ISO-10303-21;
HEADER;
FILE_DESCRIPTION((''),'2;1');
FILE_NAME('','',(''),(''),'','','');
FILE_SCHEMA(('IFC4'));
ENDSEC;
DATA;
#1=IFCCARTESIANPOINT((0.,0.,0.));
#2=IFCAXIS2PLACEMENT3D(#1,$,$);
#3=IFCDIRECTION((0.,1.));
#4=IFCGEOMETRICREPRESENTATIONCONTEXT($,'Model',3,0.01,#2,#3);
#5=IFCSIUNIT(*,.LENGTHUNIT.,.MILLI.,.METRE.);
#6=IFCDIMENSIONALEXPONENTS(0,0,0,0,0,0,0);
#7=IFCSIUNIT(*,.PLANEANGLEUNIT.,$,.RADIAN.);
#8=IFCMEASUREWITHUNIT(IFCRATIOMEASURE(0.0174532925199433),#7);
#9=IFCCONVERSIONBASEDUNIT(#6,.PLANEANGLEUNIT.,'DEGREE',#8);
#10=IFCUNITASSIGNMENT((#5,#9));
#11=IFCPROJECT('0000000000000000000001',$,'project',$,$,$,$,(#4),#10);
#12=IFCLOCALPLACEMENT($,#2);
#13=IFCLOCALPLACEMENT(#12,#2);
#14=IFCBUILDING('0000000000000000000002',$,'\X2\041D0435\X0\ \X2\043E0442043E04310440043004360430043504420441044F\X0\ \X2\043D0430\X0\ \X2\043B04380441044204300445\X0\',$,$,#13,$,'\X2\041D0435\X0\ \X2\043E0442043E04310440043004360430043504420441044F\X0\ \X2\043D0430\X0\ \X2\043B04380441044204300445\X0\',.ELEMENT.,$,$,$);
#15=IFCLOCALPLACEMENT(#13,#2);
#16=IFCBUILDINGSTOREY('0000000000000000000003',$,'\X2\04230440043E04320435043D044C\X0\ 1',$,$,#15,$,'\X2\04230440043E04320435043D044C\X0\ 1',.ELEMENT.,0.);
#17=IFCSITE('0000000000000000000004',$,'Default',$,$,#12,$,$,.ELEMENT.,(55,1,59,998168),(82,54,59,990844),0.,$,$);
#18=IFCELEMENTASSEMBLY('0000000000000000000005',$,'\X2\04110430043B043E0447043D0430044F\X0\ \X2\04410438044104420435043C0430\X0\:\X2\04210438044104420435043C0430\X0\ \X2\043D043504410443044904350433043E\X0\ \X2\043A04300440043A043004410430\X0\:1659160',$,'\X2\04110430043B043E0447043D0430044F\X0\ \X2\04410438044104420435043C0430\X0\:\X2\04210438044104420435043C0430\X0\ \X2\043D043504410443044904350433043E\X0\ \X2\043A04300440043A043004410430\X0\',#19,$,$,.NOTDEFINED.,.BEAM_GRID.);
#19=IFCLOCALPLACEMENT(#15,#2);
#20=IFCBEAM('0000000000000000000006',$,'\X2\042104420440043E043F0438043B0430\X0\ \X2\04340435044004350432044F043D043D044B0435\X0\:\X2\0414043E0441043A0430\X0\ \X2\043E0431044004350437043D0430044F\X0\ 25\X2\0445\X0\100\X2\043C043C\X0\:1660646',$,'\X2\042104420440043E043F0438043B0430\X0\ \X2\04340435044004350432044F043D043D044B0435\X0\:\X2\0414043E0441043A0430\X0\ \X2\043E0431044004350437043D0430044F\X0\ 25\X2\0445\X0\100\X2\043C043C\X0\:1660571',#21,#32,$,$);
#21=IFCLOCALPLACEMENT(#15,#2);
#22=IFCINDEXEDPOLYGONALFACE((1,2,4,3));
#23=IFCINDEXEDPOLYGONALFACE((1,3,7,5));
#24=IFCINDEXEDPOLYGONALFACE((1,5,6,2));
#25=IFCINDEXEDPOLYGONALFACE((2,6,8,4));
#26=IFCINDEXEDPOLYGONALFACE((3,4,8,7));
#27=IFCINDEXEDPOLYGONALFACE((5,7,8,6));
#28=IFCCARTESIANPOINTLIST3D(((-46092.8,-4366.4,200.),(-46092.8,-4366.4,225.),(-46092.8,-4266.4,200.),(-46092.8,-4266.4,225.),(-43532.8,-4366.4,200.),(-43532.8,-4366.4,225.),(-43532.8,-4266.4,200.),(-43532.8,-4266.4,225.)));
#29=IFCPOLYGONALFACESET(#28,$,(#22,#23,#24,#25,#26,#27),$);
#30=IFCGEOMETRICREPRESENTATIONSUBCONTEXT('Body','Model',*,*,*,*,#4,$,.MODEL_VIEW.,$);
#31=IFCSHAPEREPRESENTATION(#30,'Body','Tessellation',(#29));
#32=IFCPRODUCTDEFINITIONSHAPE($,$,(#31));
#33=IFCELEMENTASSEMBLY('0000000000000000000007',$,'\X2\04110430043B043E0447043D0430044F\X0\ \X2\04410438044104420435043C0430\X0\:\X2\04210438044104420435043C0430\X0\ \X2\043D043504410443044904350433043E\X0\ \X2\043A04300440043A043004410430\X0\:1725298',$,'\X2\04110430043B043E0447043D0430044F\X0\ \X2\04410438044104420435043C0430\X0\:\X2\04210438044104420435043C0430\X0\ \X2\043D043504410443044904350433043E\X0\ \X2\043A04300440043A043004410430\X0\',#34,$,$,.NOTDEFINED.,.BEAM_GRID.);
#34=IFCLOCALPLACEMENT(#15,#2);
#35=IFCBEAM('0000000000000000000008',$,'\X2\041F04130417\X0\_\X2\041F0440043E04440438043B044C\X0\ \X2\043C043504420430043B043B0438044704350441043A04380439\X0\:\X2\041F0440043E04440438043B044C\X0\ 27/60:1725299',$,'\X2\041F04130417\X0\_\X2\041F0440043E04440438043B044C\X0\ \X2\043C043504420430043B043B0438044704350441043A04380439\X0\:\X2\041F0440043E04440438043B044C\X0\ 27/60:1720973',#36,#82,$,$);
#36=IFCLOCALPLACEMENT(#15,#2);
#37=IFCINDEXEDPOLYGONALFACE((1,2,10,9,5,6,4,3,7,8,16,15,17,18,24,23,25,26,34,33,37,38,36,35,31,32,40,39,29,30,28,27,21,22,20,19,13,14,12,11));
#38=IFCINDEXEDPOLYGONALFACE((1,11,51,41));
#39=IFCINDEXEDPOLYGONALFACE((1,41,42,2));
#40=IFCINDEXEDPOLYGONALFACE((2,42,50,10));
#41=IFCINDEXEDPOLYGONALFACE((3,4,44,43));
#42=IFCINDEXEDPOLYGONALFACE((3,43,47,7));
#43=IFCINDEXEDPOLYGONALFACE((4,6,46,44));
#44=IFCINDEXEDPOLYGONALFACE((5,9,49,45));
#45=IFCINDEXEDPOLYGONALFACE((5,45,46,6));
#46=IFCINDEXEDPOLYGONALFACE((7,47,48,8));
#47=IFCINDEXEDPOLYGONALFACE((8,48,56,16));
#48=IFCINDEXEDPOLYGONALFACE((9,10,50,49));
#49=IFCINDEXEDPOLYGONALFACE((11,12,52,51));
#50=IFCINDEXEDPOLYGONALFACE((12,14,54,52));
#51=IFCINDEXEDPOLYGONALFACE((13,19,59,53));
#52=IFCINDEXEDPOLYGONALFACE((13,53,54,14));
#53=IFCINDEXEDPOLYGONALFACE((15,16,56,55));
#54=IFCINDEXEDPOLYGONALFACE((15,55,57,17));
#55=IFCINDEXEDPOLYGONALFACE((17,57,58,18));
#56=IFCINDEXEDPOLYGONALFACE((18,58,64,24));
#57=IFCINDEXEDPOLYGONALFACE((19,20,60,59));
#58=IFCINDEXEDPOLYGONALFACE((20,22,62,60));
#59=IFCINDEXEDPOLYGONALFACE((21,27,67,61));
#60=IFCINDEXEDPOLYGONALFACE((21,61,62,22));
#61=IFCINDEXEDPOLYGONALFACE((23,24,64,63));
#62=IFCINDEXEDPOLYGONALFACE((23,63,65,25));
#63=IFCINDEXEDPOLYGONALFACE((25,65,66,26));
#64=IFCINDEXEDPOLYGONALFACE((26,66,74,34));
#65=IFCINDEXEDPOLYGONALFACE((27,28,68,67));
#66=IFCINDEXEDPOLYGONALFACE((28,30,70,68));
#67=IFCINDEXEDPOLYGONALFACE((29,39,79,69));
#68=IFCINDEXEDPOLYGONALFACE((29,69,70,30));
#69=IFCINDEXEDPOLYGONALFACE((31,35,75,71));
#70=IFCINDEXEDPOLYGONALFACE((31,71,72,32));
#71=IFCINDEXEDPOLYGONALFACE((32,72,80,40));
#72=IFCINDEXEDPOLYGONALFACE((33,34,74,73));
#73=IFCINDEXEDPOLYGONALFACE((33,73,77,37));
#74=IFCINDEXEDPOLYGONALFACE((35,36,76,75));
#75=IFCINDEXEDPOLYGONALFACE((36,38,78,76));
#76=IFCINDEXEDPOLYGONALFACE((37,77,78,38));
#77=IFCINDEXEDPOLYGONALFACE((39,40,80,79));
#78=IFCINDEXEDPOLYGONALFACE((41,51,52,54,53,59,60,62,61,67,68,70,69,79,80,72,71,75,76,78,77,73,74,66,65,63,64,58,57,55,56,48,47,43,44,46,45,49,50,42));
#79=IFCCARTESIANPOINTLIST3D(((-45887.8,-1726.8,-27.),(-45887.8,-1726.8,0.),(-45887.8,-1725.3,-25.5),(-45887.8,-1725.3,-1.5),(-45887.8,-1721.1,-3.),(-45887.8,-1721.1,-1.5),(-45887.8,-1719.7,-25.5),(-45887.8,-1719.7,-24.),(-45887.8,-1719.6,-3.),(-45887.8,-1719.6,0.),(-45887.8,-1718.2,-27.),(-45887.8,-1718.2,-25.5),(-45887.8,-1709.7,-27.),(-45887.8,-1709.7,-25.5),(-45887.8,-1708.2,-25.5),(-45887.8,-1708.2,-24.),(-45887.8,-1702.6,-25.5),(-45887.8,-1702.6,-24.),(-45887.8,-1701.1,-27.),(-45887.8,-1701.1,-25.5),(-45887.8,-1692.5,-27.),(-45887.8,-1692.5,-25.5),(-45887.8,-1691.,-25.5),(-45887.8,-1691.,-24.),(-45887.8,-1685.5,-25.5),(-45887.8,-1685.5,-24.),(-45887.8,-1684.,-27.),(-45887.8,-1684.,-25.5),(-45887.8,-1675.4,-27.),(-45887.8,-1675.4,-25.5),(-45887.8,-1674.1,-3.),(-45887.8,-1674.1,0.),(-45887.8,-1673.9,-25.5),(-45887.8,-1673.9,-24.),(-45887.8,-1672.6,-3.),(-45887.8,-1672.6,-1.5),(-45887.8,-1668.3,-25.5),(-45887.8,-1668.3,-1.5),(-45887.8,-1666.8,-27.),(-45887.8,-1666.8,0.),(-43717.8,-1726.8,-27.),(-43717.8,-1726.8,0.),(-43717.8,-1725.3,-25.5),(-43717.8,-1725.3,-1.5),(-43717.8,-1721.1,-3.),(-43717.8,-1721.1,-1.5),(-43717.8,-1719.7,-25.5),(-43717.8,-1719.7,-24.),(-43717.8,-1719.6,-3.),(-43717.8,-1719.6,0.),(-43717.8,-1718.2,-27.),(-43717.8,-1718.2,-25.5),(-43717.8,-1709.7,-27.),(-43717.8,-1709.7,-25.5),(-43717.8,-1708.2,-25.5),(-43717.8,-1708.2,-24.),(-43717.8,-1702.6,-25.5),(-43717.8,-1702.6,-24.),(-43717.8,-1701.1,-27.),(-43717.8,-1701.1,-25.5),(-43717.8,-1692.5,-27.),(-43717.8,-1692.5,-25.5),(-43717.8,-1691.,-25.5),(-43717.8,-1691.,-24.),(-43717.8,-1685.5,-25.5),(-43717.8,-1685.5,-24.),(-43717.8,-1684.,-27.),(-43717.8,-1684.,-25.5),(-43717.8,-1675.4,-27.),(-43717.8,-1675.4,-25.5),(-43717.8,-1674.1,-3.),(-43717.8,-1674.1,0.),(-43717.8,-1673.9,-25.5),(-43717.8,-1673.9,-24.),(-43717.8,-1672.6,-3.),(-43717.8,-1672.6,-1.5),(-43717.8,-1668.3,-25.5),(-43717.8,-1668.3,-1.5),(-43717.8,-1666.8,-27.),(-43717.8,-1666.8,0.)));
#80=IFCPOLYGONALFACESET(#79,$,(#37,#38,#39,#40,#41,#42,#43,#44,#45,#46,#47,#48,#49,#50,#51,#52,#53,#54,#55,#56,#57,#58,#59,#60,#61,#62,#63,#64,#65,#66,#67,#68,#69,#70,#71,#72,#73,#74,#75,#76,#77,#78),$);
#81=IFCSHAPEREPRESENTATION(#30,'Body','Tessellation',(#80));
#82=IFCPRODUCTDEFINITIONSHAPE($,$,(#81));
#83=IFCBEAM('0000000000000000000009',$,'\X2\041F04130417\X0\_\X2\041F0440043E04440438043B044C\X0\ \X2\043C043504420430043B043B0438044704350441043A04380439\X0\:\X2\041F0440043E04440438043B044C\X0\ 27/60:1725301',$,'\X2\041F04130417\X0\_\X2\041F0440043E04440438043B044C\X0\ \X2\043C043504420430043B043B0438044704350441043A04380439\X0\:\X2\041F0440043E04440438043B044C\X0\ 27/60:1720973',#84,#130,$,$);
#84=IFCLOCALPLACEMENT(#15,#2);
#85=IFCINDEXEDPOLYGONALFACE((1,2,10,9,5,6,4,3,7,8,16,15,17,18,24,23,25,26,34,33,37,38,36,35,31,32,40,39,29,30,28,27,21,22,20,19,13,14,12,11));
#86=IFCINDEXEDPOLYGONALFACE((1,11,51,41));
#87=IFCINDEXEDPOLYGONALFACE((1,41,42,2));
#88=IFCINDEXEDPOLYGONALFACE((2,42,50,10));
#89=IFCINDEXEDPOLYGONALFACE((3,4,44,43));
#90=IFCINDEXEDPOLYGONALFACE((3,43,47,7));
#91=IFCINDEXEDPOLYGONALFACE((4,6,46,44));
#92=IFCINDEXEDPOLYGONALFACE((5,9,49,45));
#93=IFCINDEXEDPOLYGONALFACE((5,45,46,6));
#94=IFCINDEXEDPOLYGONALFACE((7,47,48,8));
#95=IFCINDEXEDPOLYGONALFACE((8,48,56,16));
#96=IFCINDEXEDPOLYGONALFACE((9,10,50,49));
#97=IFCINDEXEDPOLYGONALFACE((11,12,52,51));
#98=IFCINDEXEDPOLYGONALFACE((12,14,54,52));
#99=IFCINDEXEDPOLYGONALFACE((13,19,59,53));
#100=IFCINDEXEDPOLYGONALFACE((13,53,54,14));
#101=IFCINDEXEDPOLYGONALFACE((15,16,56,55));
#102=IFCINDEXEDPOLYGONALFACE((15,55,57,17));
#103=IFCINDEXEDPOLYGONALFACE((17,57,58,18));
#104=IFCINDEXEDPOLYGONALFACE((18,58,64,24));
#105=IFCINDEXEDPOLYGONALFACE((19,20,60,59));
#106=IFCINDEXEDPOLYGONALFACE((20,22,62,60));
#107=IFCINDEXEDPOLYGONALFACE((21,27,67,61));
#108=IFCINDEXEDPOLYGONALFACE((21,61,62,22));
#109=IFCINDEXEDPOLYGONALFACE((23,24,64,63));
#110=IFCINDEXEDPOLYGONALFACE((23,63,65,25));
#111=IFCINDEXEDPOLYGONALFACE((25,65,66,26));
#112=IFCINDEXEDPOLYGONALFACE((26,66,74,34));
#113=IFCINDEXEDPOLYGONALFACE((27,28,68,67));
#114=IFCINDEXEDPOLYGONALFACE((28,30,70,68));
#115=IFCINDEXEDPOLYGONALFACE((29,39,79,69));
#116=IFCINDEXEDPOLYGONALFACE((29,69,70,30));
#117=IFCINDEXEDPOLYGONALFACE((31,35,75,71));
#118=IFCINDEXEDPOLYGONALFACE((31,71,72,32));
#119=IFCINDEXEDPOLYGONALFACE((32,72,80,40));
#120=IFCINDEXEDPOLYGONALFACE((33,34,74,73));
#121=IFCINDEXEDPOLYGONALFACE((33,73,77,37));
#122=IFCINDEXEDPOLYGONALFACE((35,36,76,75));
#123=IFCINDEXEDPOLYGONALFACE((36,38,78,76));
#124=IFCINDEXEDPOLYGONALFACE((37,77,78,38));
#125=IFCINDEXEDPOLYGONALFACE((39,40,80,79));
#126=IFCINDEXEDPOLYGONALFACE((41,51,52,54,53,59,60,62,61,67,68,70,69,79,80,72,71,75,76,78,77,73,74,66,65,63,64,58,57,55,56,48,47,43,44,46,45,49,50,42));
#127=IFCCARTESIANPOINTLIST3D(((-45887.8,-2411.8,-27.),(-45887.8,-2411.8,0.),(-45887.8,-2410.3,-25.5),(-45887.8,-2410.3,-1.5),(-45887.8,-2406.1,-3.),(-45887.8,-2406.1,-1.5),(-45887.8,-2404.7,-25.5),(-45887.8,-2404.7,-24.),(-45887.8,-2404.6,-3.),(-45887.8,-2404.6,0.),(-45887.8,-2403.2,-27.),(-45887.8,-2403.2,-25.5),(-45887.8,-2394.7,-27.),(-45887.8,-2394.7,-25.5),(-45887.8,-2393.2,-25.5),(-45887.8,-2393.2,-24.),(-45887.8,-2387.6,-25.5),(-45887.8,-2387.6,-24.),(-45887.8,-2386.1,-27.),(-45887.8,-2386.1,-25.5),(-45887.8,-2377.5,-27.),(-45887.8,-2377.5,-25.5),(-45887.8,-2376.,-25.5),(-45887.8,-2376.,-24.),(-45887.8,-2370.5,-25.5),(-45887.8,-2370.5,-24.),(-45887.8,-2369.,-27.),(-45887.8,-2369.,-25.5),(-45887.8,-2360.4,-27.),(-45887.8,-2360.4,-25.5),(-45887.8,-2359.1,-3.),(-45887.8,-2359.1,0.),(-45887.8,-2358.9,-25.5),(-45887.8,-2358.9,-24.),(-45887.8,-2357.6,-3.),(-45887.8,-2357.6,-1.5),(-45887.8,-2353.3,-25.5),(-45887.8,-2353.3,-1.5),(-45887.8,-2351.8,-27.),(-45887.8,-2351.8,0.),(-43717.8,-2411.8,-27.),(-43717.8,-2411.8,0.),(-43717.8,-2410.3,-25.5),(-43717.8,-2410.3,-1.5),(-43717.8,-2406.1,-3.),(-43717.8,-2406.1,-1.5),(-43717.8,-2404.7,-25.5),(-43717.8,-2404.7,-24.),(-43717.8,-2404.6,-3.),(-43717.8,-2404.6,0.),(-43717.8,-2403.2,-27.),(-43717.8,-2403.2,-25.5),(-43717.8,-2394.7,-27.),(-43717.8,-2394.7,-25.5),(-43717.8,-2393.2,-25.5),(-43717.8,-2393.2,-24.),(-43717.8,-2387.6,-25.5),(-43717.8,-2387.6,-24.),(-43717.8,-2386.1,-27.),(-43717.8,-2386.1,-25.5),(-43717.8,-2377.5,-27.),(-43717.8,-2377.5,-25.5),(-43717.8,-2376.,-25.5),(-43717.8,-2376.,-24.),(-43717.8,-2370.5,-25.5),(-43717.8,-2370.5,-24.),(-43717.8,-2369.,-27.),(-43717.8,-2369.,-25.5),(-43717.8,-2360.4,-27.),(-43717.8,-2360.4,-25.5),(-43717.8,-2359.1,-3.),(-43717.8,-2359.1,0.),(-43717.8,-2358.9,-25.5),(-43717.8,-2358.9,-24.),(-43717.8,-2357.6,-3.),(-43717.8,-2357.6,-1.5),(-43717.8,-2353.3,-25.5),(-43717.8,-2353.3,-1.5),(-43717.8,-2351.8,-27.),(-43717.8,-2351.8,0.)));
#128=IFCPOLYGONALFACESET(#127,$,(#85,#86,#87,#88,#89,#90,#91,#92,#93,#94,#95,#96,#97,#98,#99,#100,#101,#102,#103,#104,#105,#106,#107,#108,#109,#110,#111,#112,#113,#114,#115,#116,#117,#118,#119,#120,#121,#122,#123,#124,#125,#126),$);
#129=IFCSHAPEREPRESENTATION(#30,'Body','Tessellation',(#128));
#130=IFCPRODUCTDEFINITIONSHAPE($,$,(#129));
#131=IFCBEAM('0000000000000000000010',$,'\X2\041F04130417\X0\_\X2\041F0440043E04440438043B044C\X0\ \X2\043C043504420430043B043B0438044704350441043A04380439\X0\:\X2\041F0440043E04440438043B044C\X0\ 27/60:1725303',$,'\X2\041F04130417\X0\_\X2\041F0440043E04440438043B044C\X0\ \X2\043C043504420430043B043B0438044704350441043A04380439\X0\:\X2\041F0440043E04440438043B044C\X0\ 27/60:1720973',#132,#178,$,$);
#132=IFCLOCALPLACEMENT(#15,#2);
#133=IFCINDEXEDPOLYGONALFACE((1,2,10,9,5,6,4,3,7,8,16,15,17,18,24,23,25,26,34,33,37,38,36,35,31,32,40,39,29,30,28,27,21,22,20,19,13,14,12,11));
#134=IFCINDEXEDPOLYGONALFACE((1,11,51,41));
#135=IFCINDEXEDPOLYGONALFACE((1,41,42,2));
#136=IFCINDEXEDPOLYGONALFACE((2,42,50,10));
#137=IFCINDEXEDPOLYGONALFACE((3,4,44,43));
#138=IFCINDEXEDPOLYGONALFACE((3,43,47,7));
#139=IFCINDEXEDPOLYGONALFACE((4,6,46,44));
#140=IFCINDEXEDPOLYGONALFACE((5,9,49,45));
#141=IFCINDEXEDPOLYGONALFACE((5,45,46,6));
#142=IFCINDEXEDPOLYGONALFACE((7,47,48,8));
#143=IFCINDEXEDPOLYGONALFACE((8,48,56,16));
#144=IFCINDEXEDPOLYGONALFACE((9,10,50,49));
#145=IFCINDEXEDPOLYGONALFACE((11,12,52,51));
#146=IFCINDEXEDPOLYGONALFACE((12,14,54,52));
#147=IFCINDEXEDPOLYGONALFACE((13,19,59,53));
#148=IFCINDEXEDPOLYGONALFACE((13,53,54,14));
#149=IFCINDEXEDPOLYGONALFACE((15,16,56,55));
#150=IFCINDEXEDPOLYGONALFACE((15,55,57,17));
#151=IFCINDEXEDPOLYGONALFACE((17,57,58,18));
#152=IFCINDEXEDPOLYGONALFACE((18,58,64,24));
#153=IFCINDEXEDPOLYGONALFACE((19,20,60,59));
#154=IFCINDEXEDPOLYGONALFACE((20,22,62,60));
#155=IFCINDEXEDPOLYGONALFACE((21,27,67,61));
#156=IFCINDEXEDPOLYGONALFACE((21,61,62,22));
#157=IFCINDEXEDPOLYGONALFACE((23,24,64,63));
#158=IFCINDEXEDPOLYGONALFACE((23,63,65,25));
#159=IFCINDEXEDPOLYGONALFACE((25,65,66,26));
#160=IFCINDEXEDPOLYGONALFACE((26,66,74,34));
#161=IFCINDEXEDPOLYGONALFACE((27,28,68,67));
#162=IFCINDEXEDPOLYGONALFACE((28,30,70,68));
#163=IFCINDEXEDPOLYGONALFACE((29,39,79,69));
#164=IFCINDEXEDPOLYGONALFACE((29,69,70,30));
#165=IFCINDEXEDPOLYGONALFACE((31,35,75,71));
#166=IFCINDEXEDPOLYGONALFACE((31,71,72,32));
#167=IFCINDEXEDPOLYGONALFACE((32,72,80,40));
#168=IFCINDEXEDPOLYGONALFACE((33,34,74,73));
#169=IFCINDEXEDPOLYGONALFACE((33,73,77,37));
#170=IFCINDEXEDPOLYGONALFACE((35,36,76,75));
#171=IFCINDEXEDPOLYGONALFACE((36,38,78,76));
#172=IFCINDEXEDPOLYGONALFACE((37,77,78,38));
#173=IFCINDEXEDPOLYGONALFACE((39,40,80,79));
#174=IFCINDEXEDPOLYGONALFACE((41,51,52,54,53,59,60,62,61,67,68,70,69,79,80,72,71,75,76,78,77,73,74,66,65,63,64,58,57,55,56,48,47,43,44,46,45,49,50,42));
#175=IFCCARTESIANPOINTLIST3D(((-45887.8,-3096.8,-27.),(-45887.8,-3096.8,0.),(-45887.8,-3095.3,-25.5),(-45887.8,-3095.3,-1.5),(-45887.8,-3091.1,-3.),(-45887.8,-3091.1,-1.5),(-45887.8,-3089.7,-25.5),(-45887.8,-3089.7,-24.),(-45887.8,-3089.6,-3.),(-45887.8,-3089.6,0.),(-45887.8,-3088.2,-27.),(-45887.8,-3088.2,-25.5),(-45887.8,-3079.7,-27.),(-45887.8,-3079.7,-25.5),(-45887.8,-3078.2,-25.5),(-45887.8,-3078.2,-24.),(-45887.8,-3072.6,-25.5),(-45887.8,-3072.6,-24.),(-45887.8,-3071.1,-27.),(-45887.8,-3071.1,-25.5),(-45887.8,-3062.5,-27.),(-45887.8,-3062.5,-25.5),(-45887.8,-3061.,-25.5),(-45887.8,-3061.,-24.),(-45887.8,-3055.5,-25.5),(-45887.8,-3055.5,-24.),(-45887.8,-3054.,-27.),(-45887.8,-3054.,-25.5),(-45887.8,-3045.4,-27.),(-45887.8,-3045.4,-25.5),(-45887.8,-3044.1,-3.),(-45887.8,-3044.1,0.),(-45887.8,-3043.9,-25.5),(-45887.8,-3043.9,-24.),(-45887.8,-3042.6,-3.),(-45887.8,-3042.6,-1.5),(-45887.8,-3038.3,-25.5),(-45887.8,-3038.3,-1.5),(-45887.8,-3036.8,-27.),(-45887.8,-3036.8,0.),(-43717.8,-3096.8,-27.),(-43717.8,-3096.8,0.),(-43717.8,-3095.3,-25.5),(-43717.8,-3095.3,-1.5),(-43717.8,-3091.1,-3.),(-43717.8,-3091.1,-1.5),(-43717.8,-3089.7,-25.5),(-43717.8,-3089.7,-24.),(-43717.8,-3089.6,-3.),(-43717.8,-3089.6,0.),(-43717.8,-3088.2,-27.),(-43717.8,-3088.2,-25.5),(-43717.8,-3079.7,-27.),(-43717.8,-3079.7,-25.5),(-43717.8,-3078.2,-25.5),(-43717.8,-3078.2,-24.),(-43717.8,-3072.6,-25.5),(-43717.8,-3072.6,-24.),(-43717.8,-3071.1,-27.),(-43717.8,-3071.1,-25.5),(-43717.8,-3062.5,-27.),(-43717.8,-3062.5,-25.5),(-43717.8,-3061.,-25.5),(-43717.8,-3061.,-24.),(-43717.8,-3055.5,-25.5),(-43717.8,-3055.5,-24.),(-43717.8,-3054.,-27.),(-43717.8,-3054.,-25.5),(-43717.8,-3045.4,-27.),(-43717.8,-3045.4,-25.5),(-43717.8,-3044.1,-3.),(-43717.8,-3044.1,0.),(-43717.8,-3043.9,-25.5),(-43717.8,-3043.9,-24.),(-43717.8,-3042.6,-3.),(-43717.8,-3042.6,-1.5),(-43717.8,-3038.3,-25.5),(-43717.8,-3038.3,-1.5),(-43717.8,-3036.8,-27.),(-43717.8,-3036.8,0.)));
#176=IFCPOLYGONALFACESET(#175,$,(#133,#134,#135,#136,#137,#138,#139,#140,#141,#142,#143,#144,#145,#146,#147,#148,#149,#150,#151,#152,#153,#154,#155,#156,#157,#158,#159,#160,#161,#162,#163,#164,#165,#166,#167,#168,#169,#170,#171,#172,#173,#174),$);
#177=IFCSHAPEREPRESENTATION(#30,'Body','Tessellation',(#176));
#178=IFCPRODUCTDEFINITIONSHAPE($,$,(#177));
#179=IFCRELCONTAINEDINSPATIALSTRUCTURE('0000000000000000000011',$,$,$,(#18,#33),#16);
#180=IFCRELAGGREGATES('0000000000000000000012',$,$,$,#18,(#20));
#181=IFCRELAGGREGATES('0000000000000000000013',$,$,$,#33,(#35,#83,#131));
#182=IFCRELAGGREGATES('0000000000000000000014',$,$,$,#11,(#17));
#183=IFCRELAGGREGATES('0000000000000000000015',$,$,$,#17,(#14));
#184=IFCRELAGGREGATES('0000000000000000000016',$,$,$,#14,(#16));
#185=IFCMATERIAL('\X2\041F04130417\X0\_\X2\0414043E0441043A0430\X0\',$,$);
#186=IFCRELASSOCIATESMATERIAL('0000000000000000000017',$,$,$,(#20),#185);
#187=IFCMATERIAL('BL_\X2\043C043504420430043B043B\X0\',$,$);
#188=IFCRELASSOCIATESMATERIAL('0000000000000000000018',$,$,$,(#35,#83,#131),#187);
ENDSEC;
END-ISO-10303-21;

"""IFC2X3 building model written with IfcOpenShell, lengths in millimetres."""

from ifc_helpers import new_model, entity, si_unit, converted_unit, direction, frame, origin, origin_2d_with_axis, place, context, subcontext, project, spatial, polyline, rectangle, outline, extrude, material, element, aggregate, save


model = new_model("IFC2X3")

# Units and contexts
model_context = context("Model", 3, precision=0.01, world=origin(), true_north=direction((0.0, 1.0)))
body_context = subcontext(model_context, "Body", "Model", "MODEL_VIEW")
ifc_project = project(units=[si_unit("LENGTHUNIT", "METRE", prefix="MILLI"), converted_unit("PLANEANGLEUNIT", "DEGREE", entity("IfcRatioMeasure", 0.0174532925199433), si_unit("PLANEANGLEUNIT", "RADIAN"), dimensions=[0, 0, 0, 0, 0, 0, 0])], contexts=[model_context])

# Site, building, storey
site_placement = place(None, origin())
site = spatial("IfcSite", under=ifc_project, at=site_placement, Name="Default", CompositionType="ELEMENT", RefLatitude=(55, 1, 59, 998168), RefLongitude=(82, 54, 59, 990844), RefElevation=0.0)
building_placement = place(site_placement, origin())
building = spatial("IfcBuilding", under=site, at=building_placement, Name="Не отображается на листах", LongName="Не отображается на листах", CompositionType="ELEMENT")
storey_placement = place(building_placement, frame((0.0, 0.0, 0.0)))
storey = spatial("IfcBuildingStorey", under=building, at=storey_placement, Name="Уровень 1", LongName="Уровень 1", CompositionType="ELEMENT", Elevation=0.0)

# Element assemblies, beams
ifc_material_1 = material(Name="ПГЗ_Доска")
assembly_1_placement = place(storey_placement, origin())
assembly_1 = element("IfcElementAssembly", 1, at=assembly_1_placement, inside=storey, Name="Балочная система:Система несущего каркаса:1659160", ObjectType="Балочная система:Система несущего каркаса", AssemblyPlace="NOTDEFINED", PredefinedType="BEAM_GRID")
beam_1_placement = place(assembly_1_placement, frame((-46092.8, -4316.4, 0.0)))
beam_1 = element("IfcBeam", 2, at=beam_1_placement, material=ifc_material_1, Name="Стропила деревянные:Доска обрезная 25х100мм:1660646", ObjectType="Стропила деревянные:Доска обрезная 25х100мм:1660571", context=body_context, shape_type="SweptSolid", body=[
    extrude(rectangle(XDim=25.0, YDim=100.0, at=origin_2d_with_axis()), frame((0.0, 0.0, 212.5), z_axis=(1.0, 0.0, 0.0), x_axis=(0.0, 0.0, -1.0)), (0.0, 0.0, 1.0), 2560.0),
])
aggregate(assembly_1, [beam_1])
assembly_2_placement = place(storey_placement, origin())
assembly_2 = element("IfcElementAssembly", 3, at=assembly_2_placement, inside=storey, Name="Балочная система:Система несущего каркаса:1725298", ObjectType="Балочная система:Система несущего каркаса", AssemblyPlace="NOTDEFINED", PredefinedType="BEAM_GRID")
ifc_material_2 = material(Name="BL_металл")
beam_2_placement = place(assembly_2_placement, frame((-45887.8, -1696.8, 0.0)))
beam_2 = element("IfcBeam", 4, at=beam_2_placement, material=ifc_material_2, Name="ПГЗ_Профиль металлический:Профиль 27/60:1725299", ObjectType="ПГЗ_Профиль металлический:Профиль 27/60:1720973", context=body_context, shape_type="SweptSolid", body=[
    extrude(outline(polyline([(-18.4, -30.0), (8.6, -30.0), (8.6, -21.4), (7.1, -21.4), (7.1, -12.9), (8.6, -12.9), (8.6, -4.3), (7.1, -4.3), (7.1, 4.3), (8.6, 4.3), (8.6, 12.9), (7.1, 12.9), (7.1, 21.4), (8.6, 21.4), (8.6, 30.0), (-18.4, 30.0), (-18.4, 22.7), (-15.4, 22.7), (-15.4, 24.2), (-16.9, 24.2), (-16.9, 28.5), (7.1, 28.5), (7.1, 22.9), (5.6, 22.9), (5.6, 11.4), (7.1, 11.4), (7.1, 5.8), (5.6, 5.8), (5.6, -5.8), (7.1, -5.8), (7.1, -11.4), (5.6, -11.4), (5.6, -22.9), (7.1, -22.9), (7.1, -28.5), (-16.9, -28.5), (-16.9, -24.2), (-15.4, -24.2), (-15.4, -22.7), (-18.4, -22.7), (-18.4, -30.0)])), frame((0.0, 0.0, -18.4), z_axis=(1.0, 0.0, 0.0), x_axis=(0.0, 0.0, -1.0)), (0.0, 0.0, 1.0), 2170.0),
])
beam_3_placement = place(assembly_2_placement, frame((-45887.8, -2381.8, 0.0)))
beam_3 = element("IfcBeam", 5, at=beam_3_placement, material=ifc_material_2, Name="ПГЗ_Профиль металлический:Профиль 27/60:1725301", ObjectType="ПГЗ_Профиль металлический:Профиль 27/60:1720973", context=body_context, shape_type="SweptSolid", body=[
    extrude(outline(polyline([(-18.4, -30.0), (8.6, -30.0), (8.6, -21.4), (7.1, -21.4), (7.1, -12.9), (8.6, -12.9), (8.6, -4.3), (7.1, -4.3), (7.1, 4.3), (8.6, 4.3), (8.6, 12.9), (7.1, 12.9), (7.1, 21.4), (8.6, 21.4), (8.6, 30.0), (-18.4, 30.0), (-18.4, 22.7), (-15.4, 22.7), (-15.4, 24.2), (-16.9, 24.2), (-16.9, 28.5), (7.1, 28.5), (7.1, 22.9), (5.6, 22.9), (5.6, 11.4), (7.1, 11.4), (7.1, 5.8), (5.6, 5.8), (5.6, -5.8), (7.1, -5.8), (7.1, -11.4), (5.6, -11.4), (5.6, -22.9), (7.1, -22.9), (7.1, -28.5), (-16.9, -28.5), (-16.9, -24.2), (-15.4, -24.2), (-15.4, -22.7), (-18.4, -22.7), (-18.4, -30.0)])), frame((0.0, 0.0, -18.4), z_axis=(1.0, 0.0, 0.0), x_axis=(0.0, 0.0, -1.0)), (0.0, 0.0, 1.0), 2170.0),
])
beam_4_placement = place(assembly_2_placement, frame((-45887.8, -3066.8, 0.0)))
beam_4 = element("IfcBeam", 6, at=beam_4_placement, material=ifc_material_2, Name="ПГЗ_Профиль металлический:Профиль 27/60:1725303", ObjectType="ПГЗ_Профиль металлический:Профиль 27/60:1720973", context=body_context, shape_type="SweptSolid", body=[
    extrude(outline(polyline([(-18.4, -30.0), (8.6, -30.0), (8.6, -21.4), (7.1, -21.4), (7.1, -12.9), (8.6, -12.9), (8.6, -4.3), (7.1, -4.3), (7.1, 4.3), (8.6, 4.3), (8.6, 12.9), (7.1, 12.9), (7.1, 21.4), (8.6, 21.4), (8.6, 30.0), (-18.4, 30.0), (-18.4, 22.7), (-15.4, 22.7), (-15.4, 24.2), (-16.9, 24.2), (-16.9, 28.5), (7.1, 28.5), (7.1, 22.9), (5.6, 22.9), (5.6, 11.4), (7.1, 11.4), (7.1, 5.8), (5.6, 5.8), (5.6, -5.8), (7.1, -5.8), (7.1, -11.4), (5.6, -11.4), (5.6, -22.9), (7.1, -22.9), (7.1, -28.5), (-16.9, -28.5), (-16.9, -24.2), (-15.4, -24.2), (-15.4, -22.7), (-18.4, -22.7), (-18.4, -30.0)])), frame((0.0, 0.0, -18.4), z_axis=(1.0, 0.0, 0.0), x_axis=(0.0, 0.0, -1.0)), (0.0, 0.0, 1.0), 2170.0),
])
aggregate(assembly_2, [beam_2, beam_3, beam_4])

save(model, "model.ifc")
